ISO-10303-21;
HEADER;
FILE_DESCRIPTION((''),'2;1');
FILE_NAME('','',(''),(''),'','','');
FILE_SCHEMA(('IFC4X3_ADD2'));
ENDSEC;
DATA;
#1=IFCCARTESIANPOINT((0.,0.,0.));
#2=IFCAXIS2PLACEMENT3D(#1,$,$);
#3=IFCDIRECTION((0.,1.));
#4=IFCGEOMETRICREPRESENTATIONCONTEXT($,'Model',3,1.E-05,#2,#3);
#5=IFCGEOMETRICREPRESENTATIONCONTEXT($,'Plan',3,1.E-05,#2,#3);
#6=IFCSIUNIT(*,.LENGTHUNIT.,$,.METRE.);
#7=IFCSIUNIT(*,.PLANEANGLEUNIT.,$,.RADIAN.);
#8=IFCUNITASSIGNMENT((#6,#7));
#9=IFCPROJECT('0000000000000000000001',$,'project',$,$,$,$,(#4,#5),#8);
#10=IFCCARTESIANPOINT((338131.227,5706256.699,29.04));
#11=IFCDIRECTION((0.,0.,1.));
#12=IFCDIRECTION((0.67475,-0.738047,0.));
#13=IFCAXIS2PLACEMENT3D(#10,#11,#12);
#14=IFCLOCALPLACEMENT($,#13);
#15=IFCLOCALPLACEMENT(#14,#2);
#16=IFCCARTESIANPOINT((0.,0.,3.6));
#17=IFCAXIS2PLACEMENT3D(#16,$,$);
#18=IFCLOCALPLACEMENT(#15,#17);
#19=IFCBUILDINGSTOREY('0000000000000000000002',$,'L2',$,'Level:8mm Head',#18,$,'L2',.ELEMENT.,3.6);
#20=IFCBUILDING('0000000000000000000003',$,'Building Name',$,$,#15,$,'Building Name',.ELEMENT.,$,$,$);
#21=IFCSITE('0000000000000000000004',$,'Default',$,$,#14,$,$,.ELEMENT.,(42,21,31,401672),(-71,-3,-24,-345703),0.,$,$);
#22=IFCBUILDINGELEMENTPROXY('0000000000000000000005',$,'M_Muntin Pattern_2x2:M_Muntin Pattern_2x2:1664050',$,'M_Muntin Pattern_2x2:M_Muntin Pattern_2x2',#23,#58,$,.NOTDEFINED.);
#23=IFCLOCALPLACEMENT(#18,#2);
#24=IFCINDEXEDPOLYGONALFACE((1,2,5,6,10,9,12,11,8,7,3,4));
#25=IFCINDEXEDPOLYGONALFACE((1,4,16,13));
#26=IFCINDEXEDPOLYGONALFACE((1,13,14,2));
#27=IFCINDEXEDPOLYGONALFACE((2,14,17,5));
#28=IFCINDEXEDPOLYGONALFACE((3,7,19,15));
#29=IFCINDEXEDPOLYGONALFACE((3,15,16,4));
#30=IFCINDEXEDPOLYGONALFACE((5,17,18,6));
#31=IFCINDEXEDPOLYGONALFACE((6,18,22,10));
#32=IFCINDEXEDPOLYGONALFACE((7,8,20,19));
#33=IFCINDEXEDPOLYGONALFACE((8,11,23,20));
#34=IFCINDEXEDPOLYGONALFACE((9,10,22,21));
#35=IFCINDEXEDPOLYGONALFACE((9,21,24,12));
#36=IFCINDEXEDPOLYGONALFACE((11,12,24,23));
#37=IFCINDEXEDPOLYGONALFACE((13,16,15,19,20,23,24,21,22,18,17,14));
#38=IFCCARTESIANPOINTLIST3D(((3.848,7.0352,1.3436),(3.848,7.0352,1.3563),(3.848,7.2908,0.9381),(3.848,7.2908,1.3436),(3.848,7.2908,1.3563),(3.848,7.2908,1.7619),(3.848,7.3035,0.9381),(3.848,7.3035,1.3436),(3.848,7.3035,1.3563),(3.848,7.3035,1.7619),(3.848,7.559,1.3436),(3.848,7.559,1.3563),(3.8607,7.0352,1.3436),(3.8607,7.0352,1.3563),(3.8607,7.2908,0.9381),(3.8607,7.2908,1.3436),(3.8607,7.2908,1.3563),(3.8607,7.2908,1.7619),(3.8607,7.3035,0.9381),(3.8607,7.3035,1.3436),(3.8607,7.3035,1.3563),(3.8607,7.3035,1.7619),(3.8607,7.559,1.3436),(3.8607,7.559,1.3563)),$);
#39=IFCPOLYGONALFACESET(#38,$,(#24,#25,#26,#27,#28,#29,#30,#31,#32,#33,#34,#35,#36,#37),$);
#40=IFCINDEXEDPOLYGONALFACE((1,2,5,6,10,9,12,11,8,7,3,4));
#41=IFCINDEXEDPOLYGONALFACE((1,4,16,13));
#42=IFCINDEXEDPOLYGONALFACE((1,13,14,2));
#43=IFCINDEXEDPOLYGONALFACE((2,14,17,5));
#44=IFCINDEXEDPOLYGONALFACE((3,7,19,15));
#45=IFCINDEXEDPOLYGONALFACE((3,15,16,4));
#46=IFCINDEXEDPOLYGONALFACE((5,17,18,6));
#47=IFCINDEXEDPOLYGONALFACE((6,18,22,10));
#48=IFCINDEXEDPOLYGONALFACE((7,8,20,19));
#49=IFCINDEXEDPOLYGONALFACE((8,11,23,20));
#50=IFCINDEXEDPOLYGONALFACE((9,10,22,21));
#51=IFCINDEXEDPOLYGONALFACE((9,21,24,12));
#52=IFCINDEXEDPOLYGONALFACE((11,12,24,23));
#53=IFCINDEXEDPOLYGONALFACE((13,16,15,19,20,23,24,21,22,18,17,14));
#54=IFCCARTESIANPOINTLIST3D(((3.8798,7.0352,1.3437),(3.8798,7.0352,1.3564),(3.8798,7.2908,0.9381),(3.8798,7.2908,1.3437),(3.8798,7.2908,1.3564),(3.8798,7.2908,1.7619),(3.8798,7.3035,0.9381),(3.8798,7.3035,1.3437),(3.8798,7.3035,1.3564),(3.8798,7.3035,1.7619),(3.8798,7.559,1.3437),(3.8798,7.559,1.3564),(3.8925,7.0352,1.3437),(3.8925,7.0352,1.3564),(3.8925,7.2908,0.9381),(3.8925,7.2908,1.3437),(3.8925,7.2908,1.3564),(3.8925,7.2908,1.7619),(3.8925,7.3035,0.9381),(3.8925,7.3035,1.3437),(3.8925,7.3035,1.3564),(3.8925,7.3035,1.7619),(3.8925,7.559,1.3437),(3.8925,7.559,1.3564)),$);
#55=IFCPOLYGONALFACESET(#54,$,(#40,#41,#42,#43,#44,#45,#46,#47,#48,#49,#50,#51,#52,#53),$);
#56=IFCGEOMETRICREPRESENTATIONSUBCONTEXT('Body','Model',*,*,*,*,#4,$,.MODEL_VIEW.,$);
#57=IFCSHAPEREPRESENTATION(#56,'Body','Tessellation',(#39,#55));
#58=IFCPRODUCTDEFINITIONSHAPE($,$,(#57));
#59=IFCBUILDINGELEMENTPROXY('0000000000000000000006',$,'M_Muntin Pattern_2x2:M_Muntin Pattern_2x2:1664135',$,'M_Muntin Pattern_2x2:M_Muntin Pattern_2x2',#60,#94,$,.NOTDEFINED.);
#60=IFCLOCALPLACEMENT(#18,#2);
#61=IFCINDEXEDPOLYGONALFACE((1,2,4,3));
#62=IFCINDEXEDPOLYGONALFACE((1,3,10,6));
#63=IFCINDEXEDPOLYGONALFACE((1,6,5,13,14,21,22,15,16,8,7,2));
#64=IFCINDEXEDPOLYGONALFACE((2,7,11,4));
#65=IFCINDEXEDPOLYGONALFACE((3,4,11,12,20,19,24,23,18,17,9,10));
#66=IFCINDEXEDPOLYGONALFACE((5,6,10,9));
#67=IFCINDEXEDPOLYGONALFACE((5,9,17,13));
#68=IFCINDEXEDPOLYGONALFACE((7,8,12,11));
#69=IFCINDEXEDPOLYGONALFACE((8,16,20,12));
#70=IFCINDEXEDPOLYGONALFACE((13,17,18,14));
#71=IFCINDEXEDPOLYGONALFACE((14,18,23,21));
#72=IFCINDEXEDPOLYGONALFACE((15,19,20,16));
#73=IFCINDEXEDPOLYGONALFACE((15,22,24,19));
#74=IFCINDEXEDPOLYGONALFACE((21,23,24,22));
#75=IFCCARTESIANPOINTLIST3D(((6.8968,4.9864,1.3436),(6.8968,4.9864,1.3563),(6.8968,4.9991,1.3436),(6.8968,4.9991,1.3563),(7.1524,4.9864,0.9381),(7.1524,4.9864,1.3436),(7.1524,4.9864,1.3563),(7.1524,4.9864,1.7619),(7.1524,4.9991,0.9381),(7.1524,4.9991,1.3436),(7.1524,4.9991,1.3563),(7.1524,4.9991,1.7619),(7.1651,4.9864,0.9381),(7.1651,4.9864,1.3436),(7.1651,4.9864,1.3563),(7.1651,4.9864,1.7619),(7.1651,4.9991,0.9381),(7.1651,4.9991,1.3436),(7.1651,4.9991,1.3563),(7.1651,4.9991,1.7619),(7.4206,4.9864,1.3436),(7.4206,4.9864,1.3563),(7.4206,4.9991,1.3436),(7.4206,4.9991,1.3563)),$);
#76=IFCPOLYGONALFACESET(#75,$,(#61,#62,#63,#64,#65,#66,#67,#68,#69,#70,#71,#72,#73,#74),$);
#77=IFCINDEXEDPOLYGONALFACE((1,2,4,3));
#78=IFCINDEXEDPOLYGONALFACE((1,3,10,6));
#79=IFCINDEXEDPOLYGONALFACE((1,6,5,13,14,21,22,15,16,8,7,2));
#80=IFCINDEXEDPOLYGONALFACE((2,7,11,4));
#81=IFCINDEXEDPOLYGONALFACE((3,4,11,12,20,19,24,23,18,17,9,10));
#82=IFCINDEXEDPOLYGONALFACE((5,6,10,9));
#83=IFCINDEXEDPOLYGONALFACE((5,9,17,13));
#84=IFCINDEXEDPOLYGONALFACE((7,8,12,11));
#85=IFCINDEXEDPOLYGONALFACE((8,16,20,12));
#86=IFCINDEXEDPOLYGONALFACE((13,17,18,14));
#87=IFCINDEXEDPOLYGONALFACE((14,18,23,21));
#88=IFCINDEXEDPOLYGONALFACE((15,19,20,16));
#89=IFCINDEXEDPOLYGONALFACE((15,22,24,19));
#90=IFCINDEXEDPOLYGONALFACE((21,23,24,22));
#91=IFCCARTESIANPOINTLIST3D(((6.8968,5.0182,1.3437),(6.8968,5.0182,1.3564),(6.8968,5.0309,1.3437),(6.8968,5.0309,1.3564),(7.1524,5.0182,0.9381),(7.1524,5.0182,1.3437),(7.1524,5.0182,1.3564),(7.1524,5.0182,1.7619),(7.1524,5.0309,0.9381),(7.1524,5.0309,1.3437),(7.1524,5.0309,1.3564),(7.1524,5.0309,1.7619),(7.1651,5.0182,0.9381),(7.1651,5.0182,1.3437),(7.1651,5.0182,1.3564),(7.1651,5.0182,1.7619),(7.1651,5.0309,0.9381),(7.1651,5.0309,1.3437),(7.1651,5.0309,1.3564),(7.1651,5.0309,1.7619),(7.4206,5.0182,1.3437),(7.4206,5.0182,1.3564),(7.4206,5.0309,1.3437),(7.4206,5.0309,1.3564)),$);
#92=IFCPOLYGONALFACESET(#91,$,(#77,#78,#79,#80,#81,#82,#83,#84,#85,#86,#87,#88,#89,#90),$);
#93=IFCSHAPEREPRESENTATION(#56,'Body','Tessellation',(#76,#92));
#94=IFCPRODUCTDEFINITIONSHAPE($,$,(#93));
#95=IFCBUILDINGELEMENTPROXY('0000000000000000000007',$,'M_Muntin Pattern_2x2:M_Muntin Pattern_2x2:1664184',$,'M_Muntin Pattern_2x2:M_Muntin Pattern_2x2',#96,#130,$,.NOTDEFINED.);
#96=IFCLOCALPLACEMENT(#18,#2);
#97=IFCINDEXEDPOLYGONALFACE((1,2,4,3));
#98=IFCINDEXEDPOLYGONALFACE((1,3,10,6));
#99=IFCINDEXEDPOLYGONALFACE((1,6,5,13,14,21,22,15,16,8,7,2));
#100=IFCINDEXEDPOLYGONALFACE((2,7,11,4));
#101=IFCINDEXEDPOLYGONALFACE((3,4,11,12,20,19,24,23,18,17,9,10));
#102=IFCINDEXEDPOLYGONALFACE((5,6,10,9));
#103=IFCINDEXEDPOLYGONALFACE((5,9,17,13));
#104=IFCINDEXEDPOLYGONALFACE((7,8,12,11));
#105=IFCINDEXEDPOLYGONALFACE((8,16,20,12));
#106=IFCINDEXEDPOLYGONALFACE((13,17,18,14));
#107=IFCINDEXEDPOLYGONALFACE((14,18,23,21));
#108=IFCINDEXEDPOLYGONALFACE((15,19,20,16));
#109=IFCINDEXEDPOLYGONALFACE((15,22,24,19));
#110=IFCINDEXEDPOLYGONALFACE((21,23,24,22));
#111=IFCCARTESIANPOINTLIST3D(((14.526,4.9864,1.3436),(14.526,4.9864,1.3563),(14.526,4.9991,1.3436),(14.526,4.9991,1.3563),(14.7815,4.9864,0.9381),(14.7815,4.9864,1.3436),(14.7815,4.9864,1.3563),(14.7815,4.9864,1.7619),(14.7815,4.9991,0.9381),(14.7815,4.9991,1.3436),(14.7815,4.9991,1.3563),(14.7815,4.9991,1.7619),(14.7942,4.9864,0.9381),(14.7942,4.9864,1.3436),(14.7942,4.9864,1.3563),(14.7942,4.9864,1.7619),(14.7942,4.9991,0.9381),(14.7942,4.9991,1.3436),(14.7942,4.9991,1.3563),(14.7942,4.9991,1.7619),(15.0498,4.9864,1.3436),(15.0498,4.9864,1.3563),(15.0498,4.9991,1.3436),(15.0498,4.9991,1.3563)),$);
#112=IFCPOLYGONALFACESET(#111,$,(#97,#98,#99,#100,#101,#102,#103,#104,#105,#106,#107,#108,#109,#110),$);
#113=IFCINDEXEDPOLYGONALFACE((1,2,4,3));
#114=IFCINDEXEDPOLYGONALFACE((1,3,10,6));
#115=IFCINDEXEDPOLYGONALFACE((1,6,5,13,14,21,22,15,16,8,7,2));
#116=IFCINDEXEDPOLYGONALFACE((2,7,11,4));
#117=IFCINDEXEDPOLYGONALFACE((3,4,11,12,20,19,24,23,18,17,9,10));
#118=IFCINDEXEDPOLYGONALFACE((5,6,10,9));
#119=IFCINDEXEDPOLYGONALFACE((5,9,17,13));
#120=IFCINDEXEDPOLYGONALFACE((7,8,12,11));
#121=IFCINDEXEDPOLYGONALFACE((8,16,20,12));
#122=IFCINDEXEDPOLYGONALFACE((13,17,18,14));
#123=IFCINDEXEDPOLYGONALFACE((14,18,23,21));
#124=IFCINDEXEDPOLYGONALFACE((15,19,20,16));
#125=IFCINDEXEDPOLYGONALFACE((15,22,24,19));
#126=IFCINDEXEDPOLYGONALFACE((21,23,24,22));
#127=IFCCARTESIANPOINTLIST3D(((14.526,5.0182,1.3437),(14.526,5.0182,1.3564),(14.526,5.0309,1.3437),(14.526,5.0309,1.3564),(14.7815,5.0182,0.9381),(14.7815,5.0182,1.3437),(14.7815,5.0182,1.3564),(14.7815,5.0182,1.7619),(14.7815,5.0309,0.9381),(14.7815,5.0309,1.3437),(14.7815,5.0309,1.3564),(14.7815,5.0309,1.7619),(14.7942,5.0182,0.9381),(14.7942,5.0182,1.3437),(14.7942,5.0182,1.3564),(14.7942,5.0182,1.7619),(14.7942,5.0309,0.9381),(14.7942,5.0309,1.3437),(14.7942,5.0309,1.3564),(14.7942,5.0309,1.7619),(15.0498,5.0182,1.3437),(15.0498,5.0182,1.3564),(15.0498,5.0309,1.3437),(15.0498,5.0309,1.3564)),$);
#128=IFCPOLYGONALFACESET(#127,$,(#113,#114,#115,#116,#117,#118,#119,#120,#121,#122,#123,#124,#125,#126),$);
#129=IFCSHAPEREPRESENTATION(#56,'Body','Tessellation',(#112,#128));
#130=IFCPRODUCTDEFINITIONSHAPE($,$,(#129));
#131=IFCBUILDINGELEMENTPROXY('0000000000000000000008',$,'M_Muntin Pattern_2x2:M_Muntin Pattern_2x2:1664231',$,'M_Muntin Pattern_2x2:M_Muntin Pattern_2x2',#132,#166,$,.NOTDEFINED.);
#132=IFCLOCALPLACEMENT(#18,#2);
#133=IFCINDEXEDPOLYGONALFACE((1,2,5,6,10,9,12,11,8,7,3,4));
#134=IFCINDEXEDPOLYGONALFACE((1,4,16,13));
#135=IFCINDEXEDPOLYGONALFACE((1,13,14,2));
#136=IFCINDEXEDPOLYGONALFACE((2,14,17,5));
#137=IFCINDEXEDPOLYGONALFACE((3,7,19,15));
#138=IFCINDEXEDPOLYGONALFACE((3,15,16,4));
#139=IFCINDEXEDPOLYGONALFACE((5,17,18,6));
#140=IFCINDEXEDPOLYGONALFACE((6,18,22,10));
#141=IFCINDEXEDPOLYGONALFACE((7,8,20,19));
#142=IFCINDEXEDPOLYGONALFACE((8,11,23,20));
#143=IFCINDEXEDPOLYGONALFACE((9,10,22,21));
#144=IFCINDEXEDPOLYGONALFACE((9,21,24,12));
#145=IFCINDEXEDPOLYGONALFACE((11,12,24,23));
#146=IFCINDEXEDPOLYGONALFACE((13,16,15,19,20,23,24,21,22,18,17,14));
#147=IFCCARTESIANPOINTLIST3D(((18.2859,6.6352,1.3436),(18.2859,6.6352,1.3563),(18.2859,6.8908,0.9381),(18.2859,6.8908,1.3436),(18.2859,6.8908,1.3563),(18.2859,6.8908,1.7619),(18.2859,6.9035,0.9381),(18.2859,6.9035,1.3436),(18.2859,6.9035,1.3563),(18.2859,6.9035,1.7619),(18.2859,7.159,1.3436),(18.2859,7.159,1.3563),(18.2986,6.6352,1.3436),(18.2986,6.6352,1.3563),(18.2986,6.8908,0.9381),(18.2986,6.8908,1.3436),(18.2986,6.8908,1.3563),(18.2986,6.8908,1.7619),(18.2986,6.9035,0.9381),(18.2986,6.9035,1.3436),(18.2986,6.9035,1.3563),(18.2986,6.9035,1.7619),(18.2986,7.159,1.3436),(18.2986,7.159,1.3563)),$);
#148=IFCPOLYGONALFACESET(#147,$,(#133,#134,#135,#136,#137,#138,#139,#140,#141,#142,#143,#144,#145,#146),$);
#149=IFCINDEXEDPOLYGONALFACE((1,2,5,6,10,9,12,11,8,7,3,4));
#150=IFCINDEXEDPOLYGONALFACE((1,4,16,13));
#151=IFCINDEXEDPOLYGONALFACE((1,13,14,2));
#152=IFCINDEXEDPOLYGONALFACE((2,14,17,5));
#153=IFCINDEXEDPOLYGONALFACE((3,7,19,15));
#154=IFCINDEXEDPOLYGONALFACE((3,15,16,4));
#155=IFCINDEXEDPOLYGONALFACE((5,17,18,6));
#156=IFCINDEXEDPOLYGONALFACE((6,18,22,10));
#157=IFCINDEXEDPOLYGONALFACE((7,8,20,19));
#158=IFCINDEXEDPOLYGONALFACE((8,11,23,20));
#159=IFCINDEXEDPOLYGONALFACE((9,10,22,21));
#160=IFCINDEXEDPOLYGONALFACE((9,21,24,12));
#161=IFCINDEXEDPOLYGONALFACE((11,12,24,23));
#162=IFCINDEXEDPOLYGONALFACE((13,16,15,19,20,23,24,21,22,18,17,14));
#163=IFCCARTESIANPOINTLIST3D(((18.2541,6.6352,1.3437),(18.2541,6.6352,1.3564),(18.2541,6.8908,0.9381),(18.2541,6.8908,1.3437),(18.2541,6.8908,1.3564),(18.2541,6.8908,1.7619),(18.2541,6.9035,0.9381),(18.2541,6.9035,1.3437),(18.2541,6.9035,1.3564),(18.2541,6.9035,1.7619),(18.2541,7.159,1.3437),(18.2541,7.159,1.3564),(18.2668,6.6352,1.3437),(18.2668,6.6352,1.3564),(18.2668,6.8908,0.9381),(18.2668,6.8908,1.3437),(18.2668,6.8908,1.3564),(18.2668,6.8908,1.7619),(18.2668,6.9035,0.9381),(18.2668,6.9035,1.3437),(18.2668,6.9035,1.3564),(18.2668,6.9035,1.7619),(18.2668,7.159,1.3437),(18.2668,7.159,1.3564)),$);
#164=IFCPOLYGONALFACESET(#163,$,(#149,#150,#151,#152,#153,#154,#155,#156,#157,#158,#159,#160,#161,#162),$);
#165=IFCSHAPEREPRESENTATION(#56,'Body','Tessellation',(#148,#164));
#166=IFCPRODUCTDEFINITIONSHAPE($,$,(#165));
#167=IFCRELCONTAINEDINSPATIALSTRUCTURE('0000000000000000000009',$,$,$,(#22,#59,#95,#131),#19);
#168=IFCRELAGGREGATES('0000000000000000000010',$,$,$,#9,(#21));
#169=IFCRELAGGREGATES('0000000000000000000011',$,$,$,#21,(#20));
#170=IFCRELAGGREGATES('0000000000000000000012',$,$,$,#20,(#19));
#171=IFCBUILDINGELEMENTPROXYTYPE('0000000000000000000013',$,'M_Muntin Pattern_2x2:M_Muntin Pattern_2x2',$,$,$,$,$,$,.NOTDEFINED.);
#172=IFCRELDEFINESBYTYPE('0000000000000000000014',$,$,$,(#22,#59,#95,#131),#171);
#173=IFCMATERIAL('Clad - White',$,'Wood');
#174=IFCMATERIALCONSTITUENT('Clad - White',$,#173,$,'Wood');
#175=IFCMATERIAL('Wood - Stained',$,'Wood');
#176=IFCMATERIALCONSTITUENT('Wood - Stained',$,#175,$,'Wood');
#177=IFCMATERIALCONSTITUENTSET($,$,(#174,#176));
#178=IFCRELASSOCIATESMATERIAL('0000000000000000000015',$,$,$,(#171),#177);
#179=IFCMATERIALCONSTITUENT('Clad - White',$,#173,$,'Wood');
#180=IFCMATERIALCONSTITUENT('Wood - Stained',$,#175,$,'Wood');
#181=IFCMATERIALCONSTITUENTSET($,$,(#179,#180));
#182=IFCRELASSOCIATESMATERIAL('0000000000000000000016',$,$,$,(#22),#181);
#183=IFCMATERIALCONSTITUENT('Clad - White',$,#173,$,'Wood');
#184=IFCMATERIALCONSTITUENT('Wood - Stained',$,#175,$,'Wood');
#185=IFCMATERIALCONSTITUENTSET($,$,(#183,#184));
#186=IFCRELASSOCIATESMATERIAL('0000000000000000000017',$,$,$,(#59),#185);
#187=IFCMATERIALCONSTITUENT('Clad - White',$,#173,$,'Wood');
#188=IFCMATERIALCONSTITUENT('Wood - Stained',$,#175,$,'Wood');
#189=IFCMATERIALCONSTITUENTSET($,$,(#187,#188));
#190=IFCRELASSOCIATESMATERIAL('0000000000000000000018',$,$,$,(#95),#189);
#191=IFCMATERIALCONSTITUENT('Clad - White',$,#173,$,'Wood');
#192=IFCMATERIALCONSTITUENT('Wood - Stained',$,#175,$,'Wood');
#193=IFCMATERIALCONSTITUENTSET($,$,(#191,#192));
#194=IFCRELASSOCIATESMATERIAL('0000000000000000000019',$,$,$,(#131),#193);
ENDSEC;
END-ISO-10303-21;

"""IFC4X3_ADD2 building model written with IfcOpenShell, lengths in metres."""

from ifc_helpers import new_model, si_unit, direction, frame, origin, place, context, subcontext, project, spatial, polyline, outline, extrude, source, transform, mapped, material, constituent, constituent_set, type_object, type_shapes, element, save


model = new_model("IFC4X3_ADD2")

# Units and contexts
model_context = context("Model", 3, precision=1e-05, world=origin(), true_north=direction((0.0, 1.0)))
plan_context = context("Plan", 3, precision=1e-05, world=origin(), true_north=direction((0.0, 1.0)))
body_context = subcontext(model_context, "Body", "Model", "MODEL_VIEW")
ifc_project = project(units=[si_unit("LENGTHUNIT", "METRE"), si_unit("PLANEANGLEUNIT", "RADIAN")], contexts=[model_context, plan_context])

# Site, building, storey
site_placement = place(None, frame((338131.227, 5706256.699, 29.04), z_axis=(0.0, 0.0, 1.0), x_axis=(0.67475, -0.738047, 0.0)))
site = spatial("IfcSite", under=ifc_project, at=site_placement, Name="Default", CompositionType="ELEMENT", RefLatitude=(42, 21, 31, 401672), RefLongitude=(-71, -3, -24, -345703), RefElevation=0.0)
building_placement = place(site_placement, origin())
building = spatial("IfcBuilding", under=site, at=building_placement, Name="Building Name", LongName="Building Name", CompositionType="ELEMENT")
storey_placement = place(building_placement, frame((0.0, 0.0, 3.6)))
storey = spatial("IfcBuildingStorey", under=building, at=storey_placement, Name="L2", ObjectType="Level:8mm Head", LongName="L2", CompositionType="ELEMENT", Elevation=3.6)

# Building element proxies
ifc_material_1 = material(Name="Clad - White", Category="Wood")
ifc_material_2 = material(Name="Wood - Stained", Category="Wood")
ifc_constituent_1 = constituent(ifc_material_1, Name="Clad - White", Category="Wood")
ifc_constituent_2 = constituent(ifc_material_2, Name="Wood - Stained", Category="Wood")
ifc_constituent_set_1 = constituent_set(constituents=[ifc_constituent_1, ifc_constituent_2])
building_element_proxy_type = type_object("IfcBuildingElementProxyType", Name="M_Muntin Pattern_2x2:M_Muntin Pattern_2x2", PredefinedType="NOTDEFINED", material=ifc_constituent_set_1)
shared_shape = source(origin(), body_context, "Body", "SweptSolid", [
    extrude(outline(polyline([(0.0064, -0.0064), (0.4119, -0.0064), (0.4119, 0.0063), (0.0064, 0.0063), (0.0064, 0.2619), (-0.0063, 0.2619), (-0.0063, 0.0063), (-0.4119, 0.0063), (-0.4119, -0.0064), (-0.0063, -0.0064), (-0.0063, -0.2619), (0.0064, -0.2619), (0.0064, -0.0064)])), frame((0.0, -0.0222, 0.4119), z_axis=(0.0, 1.0, 0.0), x_axis=(0.0, 0.0, 1.0)), (0.0, 0.0, 1.0), 0.0127),
    extrude(outline(polyline([(0.0064, -0.0064), (0.4119, -0.0064), (0.4119, 0.0063), (0.0064, 0.0063), (0.0064, 0.2619), (-0.0063, 0.2619), (-0.0063, 0.0063), (-0.4119, 0.0063), (-0.4119, -0.0064), (-0.0063, -0.0064), (-0.0063, -0.2619), (0.0064, -0.2619), (0.0064, -0.0064)])), frame((0.0, 0.0095, 0.4119), z_axis=(0.0, 1.0, 0.0), x_axis=(0.0, 0.0, 1.0)), (0.0, 0.0, 1.0), 0.0127),
])
type_shapes(building_element_proxy_type, [shared_shape])
ifc_constituent_3 = constituent(ifc_material_1, Name="Clad - White", Category="Wood")
ifc_constituent_4 = constituent(ifc_material_2, Name="Wood - Stained", Category="Wood")
ifc_constituent_set_2 = constituent_set(constituents=[ifc_constituent_3, ifc_constituent_4])
proxy_1_placement = place(storey_placement, frame((3.8703, 7.2971, 0.9381), z_axis=(0.0, 0.0, 1.0), x_axis=(0.0, -1.0, 0.0)))
element("IfcBuildingElementProxy", 1, at=proxy_1_placement, inside=storey, type_object=building_element_proxy_type, material=ifc_constituent_set_2, Name="M_Muntin Pattern_2x2:M_Muntin Pattern_2x2:1664050", ObjectType="M_Muntin Pattern_2x2:M_Muntin Pattern_2x2", PredefinedType="NOTDEFINED", context=body_context, shape_type="MappedRepresentation", body=[
    mapped(shared_shape, transform((0.0, 0.0, 0.0), scale=1.0)),
])
ifc_constituent_5 = constituent(ifc_material_1, Name="Clad - White", Category="Wood")
ifc_constituent_6 = constituent(ifc_material_2, Name="Wood - Stained", Category="Wood")
ifc_constituent_set_3 = constituent_set(constituents=[ifc_constituent_5, ifc_constituent_6])
proxy_2_placement = place(storey_placement, frame((7.1587, 5.0087, 0.9381)))
element("IfcBuildingElementProxy", 2, at=proxy_2_placement, inside=storey, type_object=building_element_proxy_type, material=ifc_constituent_set_3, Name="M_Muntin Pattern_2x2:M_Muntin Pattern_2x2:1664135", ObjectType="M_Muntin Pattern_2x2:M_Muntin Pattern_2x2", PredefinedType="NOTDEFINED", context=body_context, shape_type="MappedRepresentation", body=[
    mapped(shared_shape, transform((0.0, 0.0, 0.0), scale=1.0)),
])
ifc_constituent_7 = constituent(ifc_material_1, Name="Clad - White", Category="Wood")
ifc_constituent_8 = constituent(ifc_material_2, Name="Wood - Stained", Category="Wood")
ifc_constituent_set_4 = constituent_set(constituents=[ifc_constituent_7, ifc_constituent_8])
proxy_3_placement = place(storey_placement, frame((14.7879, 5.0087, 0.9381)))
element("IfcBuildingElementProxy", 3, at=proxy_3_placement, inside=storey, type_object=building_element_proxy_type, material=ifc_constituent_set_4, Name="M_Muntin Pattern_2x2:M_Muntin Pattern_2x2:1664184", ObjectType="M_Muntin Pattern_2x2:M_Muntin Pattern_2x2", PredefinedType="NOTDEFINED", context=body_context, shape_type="MappedRepresentation", body=[
    mapped(shared_shape, transform((0.0, 0.0, 0.0), scale=1.0)),
])
ifc_constituent_9 = constituent(ifc_material_1, Name="Clad - White", Category="Wood")
ifc_constituent_10 = constituent(ifc_material_2, Name="Wood - Stained", Category="Wood")
ifc_constituent_set_5 = constituent_set(constituents=[ifc_constituent_9, ifc_constituent_10])
proxy_4_placement = place(storey_placement, frame((18.2763, 6.8971, 0.9381), z_axis=(0.0, 0.0, 1.0), x_axis=(0.0, 1.0, 0.0)))
element("IfcBuildingElementProxy", 4, at=proxy_4_placement, inside=storey, type_object=building_element_proxy_type, material=ifc_constituent_set_5, Name="M_Muntin Pattern_2x2:M_Muntin Pattern_2x2:1664231", ObjectType="M_Muntin Pattern_2x2:M_Muntin Pattern_2x2", PredefinedType="NOTDEFINED", context=body_context, shape_type="MappedRepresentation", body=[
    mapped(shared_shape, transform((0.0, 0.0, 0.0), scale=1.0)),
])

save(model, "model.ifc")
